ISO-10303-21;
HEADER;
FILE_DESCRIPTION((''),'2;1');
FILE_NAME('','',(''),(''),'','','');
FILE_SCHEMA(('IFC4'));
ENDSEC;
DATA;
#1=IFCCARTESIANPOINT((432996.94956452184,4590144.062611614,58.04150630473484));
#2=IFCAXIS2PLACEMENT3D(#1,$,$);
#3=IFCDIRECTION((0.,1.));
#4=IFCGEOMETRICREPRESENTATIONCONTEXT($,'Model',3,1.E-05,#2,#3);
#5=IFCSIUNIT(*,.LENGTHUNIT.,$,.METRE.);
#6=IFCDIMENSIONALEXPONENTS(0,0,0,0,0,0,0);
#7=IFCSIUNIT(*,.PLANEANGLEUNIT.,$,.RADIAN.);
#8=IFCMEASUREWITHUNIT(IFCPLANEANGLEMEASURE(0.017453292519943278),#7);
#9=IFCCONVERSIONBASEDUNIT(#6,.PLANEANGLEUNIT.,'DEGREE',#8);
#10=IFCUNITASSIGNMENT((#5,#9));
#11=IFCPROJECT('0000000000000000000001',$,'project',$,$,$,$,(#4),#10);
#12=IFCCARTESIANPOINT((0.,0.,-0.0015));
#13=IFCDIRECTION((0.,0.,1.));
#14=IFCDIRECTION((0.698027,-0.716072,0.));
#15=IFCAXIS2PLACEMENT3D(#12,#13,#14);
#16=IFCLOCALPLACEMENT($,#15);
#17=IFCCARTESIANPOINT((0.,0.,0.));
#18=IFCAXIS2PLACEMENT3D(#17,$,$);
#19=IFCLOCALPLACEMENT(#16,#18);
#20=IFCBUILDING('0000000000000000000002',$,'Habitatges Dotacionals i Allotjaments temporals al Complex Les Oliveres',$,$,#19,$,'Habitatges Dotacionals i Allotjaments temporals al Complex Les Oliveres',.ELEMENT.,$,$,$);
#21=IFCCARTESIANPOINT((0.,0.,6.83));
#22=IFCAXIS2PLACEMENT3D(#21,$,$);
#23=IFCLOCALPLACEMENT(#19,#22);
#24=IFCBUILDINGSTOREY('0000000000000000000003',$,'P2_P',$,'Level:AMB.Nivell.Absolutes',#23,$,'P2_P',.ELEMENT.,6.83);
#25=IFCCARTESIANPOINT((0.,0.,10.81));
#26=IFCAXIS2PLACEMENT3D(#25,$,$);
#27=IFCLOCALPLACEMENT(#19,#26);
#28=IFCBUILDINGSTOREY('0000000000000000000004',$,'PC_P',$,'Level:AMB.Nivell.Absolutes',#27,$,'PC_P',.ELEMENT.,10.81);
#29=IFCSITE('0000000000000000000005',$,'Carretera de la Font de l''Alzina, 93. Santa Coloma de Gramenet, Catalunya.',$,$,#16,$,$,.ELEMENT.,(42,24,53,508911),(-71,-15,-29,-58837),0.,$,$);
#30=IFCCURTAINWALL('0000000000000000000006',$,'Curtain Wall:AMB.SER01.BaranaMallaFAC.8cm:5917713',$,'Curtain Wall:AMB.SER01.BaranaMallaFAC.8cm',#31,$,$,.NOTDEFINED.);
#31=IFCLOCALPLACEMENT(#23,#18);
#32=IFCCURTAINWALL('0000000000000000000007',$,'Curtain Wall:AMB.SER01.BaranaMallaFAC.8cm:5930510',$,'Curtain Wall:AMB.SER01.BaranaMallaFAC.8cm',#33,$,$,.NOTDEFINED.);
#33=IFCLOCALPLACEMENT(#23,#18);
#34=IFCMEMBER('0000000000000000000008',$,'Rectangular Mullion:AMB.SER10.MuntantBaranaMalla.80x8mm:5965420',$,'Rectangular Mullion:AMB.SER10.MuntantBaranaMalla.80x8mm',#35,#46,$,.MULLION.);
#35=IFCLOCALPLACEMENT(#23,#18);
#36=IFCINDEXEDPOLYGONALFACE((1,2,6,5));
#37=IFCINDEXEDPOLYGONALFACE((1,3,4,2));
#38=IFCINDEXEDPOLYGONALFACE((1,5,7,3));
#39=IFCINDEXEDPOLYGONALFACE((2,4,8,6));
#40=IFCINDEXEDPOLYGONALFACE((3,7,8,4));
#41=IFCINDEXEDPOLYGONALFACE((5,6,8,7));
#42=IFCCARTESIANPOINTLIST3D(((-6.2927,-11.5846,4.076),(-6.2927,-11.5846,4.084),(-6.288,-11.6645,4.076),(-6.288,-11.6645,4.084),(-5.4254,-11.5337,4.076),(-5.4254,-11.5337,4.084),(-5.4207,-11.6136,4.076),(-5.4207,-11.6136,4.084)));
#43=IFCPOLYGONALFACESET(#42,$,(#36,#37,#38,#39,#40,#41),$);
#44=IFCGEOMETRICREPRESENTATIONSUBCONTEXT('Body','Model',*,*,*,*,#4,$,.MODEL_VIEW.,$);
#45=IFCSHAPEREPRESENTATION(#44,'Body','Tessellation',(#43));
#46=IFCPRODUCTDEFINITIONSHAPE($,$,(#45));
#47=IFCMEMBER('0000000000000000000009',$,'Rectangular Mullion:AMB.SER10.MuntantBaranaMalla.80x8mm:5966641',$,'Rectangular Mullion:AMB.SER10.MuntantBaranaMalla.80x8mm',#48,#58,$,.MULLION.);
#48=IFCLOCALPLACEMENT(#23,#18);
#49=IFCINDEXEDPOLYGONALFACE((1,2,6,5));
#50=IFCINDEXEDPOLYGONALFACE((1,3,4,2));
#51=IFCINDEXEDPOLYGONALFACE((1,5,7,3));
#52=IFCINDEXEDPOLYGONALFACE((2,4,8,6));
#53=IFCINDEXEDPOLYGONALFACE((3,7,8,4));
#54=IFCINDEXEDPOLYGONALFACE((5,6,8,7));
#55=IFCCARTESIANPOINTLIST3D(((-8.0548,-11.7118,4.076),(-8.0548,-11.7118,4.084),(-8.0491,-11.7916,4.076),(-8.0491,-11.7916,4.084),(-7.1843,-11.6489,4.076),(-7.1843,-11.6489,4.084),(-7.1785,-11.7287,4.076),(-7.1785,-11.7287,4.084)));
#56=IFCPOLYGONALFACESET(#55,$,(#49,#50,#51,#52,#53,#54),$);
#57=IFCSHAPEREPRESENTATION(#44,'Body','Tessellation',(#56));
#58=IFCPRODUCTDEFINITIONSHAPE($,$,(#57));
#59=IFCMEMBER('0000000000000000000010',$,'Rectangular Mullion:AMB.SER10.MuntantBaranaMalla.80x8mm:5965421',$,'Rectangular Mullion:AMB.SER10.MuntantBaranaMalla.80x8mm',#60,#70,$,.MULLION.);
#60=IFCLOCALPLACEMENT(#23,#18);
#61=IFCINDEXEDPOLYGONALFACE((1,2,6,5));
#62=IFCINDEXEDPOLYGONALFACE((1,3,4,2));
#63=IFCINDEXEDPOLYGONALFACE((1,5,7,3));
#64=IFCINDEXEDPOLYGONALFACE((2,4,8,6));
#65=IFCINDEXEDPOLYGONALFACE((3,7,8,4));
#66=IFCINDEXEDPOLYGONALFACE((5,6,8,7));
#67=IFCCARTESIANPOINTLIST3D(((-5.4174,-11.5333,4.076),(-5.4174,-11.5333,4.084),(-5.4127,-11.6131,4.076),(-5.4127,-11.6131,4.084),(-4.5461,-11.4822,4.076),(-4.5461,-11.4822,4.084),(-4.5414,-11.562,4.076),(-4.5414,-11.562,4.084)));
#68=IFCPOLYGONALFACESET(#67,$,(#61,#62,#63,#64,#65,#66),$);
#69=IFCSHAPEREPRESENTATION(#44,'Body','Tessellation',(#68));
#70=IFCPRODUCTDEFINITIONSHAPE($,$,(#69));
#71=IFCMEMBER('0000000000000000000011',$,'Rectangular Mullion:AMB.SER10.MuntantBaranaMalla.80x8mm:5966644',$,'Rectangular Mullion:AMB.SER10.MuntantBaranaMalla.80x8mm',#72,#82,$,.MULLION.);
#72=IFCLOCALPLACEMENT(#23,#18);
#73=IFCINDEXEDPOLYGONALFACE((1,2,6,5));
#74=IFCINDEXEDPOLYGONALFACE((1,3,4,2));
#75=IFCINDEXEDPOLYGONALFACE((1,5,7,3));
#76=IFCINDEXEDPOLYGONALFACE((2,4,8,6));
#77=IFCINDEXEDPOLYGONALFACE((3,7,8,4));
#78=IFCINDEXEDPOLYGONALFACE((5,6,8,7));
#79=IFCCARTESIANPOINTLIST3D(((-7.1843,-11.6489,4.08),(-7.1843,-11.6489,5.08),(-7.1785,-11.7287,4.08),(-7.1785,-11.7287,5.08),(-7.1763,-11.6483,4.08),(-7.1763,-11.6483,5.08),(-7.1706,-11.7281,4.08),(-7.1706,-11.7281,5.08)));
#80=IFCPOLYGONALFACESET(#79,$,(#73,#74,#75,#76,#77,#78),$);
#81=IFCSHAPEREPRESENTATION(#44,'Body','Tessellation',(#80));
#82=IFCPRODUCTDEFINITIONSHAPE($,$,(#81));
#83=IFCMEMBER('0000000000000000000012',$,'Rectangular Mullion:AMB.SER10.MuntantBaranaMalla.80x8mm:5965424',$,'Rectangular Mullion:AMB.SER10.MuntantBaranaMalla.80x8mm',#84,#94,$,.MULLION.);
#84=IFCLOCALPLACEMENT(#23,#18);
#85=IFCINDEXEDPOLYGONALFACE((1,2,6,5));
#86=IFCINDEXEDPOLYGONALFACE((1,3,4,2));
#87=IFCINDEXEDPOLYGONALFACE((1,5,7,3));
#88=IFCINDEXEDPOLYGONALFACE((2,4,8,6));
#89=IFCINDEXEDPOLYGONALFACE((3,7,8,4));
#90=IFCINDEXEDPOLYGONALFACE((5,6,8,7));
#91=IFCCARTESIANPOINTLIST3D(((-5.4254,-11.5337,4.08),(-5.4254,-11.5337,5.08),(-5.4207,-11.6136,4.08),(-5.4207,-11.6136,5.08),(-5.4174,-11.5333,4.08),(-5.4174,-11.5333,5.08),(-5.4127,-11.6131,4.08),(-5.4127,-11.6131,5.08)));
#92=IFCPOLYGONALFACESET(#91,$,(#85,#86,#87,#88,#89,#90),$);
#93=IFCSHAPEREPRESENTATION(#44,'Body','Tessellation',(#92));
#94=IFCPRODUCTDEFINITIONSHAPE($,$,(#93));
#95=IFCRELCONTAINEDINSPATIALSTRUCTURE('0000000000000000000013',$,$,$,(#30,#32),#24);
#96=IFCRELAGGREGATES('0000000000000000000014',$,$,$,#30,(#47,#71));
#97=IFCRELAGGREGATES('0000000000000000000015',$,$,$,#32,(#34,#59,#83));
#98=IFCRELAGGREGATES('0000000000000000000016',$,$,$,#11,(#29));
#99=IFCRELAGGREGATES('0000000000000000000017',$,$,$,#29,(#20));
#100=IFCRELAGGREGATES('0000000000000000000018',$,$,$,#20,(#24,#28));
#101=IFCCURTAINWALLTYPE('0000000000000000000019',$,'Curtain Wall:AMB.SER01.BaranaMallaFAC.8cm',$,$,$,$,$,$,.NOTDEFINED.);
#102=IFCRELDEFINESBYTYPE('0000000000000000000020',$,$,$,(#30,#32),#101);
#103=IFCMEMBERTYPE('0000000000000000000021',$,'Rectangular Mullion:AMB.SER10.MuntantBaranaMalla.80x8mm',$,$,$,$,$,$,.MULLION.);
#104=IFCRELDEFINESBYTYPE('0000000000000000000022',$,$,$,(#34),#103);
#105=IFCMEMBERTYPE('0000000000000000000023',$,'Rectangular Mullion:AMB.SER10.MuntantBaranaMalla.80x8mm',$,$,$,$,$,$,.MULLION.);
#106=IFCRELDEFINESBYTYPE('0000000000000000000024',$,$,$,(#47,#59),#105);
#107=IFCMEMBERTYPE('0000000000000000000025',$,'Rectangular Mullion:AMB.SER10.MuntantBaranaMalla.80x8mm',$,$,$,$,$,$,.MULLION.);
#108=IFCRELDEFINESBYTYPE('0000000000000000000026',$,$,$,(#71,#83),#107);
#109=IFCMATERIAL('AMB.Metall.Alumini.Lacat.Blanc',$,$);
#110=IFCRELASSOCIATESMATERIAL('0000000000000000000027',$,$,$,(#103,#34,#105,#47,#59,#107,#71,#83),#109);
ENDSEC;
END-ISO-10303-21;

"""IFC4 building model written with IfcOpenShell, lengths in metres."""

from ifc_helpers import new_model, entity, si_unit, converted_unit, direction, frame, origin, place, context, subcontext, project, spatial, indexed_curve, outline, extrude, source, transform, mapped, material, type_object, type_shapes, element, aggregate, save


model = new_model("IFC4")

# Units and contexts
model_context = context("Model", 3, precision=1e-05, world=frame((432996.94956452184, 4590144.062611614, 58.04150630473484)), true_north=direction((0.0, 1.0)))
body_context = subcontext(model_context, "Body", "Model", "MODEL_VIEW")
ifc_project = project(units=[si_unit("LENGTHUNIT", "METRE"), converted_unit("PLANEANGLEUNIT", "DEGREE", entity("IfcPlaneAngleMeasure", 0.017453292519943278), si_unit("PLANEANGLEUNIT", "RADIAN"), dimensions=[0, 0, 0, 0, 0, 0, 0])], contexts=[model_context])

# Site, building, storey
site_placement = place(None, frame((0.0, 0.0, -0.0015), z_axis=(0.0, 0.0, 1.0), x_axis=(0.698027, -0.716072, 0.0)))
site = spatial("IfcSite", under=ifc_project, at=site_placement, Name="Carretera de la Font de l'Alzina, 93. Santa Coloma de Gramenet, Catalunya.", CompositionType="ELEMENT", RefLatitude=(42, 24, 53, 508911), RefLongitude=(-71, -15, -29, -58837), RefElevation=0.0)
building_placement = place(site_placement, origin())
building = spatial("IfcBuilding", under=site, at=building_placement, Name="Habitatges Dotacionals i Allotjaments temporals al Complex Les Oliveres", LongName="Habitatges Dotacionals i Allotjaments temporals al Complex Les Oliveres", CompositionType="ELEMENT")
storey_1_placement = place(building_placement, frame((0.0, 0.0, 6.83)))
storey_1 = spatial("IfcBuildingStorey", under=building, at=storey_1_placement, Name="P2_P", ObjectType="Level:AMB.Nivell.Absolutes", LongName="P2_P", CompositionType="ELEMENT", Elevation=6.83)

# Curtain walls
curtain_wall_type = type_object("IfcCurtainWallType", Name="Curtain Wall:AMB.SER01.BaranaMallaFAC.8cm", PredefinedType="NOTDEFINED")
curtain_wall_1_placement = place(storey_1_placement, frame((0.0, 0.0, -6.83)))
curtain_wall_1 = element("IfcCurtainWall", 1, at=curtain_wall_1_placement, inside=storey_1, type_object=curtain_wall_type, Name="Curtain Wall:AMB.SER01.BaranaMallaFAC.8cm:5917713", ObjectType="Curtain Wall:AMB.SER01.BaranaMallaFAC.8cm", PredefinedType="NOTDEFINED")
ifc_material_1 = material(Name="AMB.Metall.Alumini.Lacat.Blanc")
curtain_wall_2_placement = place(storey_1_placement, frame((0.0, 0.0, -6.83)))
curtain_wall_2 = element("IfcCurtainWall", 2, at=curtain_wall_2_placement, inside=storey_1, type_object=curtain_wall_type, Name="Curtain Wall:AMB.SER01.BaranaMallaFAC.8cm:5930510", ObjectType="Curtain Wall:AMB.SER01.BaranaMallaFAC.8cm", PredefinedType="NOTDEFINED")

# Members
member_type_1 = type_object("IfcMemberType", Name="Rectangular Mullion:AMB.SER10.MuntantBaranaMalla.80x8mm", PredefinedType="MULLION", material=ifc_material_1)
shared_shape_1 = source(origin(), body_context, "Body", "SweptSolid", [
    extrude(outline(indexed_curve([(-0.004, -0.04), (0.004, -0.04), (0.004, 0.04), (-0.004, 0.04), (-0.004, -0.04)], self_intersect=False)), frame((0.0, -0.04, -0.8688), z_axis=(0.0, 0.0, 1.0), x_axis=(-1.0, 0.0, 0.0)), (0.0, 0.0, 1.0), 0.8688),
])
type_shapes(member_type_1, [shared_shape_1])
member_1_placement = place(curtain_wall_2_placement, frame((-5.4207, -11.6136, 10.91), z_axis=(0.998284, 0.058552, 0.0), x_axis=(0.0, 0.0, 1.0)))
member_1 = element("IfcMember", 3, at=member_1_placement, type_object=member_type_1, material=ifc_material_1, Name="Rectangular Mullion:AMB.SER10.MuntantBaranaMalla.80x8mm:5965420", ObjectType="Rectangular Mullion:AMB.SER10.MuntantBaranaMalla.80x8mm", PredefinedType="MULLION", context=body_context, shape_type="MappedRepresentation", body=[
    mapped(shared_shape_1, transform((0.0, 0.0, 0.0), scale=1.0)),
])
member_type_2 = type_object("IfcMemberType", Name="Rectangular Mullion:AMB.SER10.MuntantBaranaMalla.80x8mm", PredefinedType="MULLION", material=ifc_material_1)
shared_shape_2 = source(origin(), body_context, "Body", "SweptSolid", [
    extrude(outline(indexed_curve([(-0.004, -0.04), (0.004, -0.04), (0.004, 0.04), (-0.004, 0.04), (-0.004, -0.04)], self_intersect=False)), frame((0.0, -0.04, -0.8728), z_axis=(0.0, 0.0, 1.0), x_axis=(-1.0, 0.0, 0.0)), (0.0, 0.0, 1.0), 0.8728),
])
type_shapes(member_type_2, [shared_shape_2])
member_2_placement = place(curtain_wall_1_placement, frame((-7.1785, -11.7287, 10.91), z_axis=(0.9974, 0.072068, 0.0), x_axis=(0.0, 0.0, 1.0)))
member_2 = element("IfcMember", 4, at=member_2_placement, type_object=member_type_2, material=ifc_material_1, Name="Rectangular Mullion:AMB.SER10.MuntantBaranaMalla.80x8mm:5966641", ObjectType="Rectangular Mullion:AMB.SER10.MuntantBaranaMalla.80x8mm", PredefinedType="MULLION", context=body_context, shape_type="MappedRepresentation", body=[
    mapped(shared_shape_2, transform((0.0, 0.0, 0.0), scale=1.0)),
])
member_3_placement = place(curtain_wall_2_placement, frame((-4.5414, -11.562, 10.91), z_axis=(0.998284, 0.058552, 0.0), x_axis=(0.0, 0.0, 1.0)))
member_3 = element("IfcMember", 5, at=member_3_placement, type_object=member_type_2, material=ifc_material_1, Name="Rectangular Mullion:AMB.SER10.MuntantBaranaMalla.80x8mm:5965421", ObjectType="Rectangular Mullion:AMB.SER10.MuntantBaranaMalla.80x8mm", PredefinedType="MULLION", context=body_context, shape_type="MappedRepresentation", body=[
    mapped(shared_shape_2, transform((0.0, 0.0, 0.0), scale=1.0)),
])
member_type_3 = type_object("IfcMemberType", Name="Rectangular Mullion:AMB.SER10.MuntantBaranaMalla.80x8mm", PredefinedType="MULLION", material=ifc_material_1)
shared_shape_3 = source(origin(), body_context, "Body", "SweptSolid", [
    extrude(outline(indexed_curve([(-0.004, -0.04), (0.004, -0.04), (0.004, 0.04), (-0.004, 0.04), (-0.004, -0.04)], self_intersect=False)), frame((0.0, -0.04, -1.0), z_axis=(0.0, 0.0, 1.0), x_axis=(-1.0, 0.0, 0.0)), (0.0, 0.0, 1.0), 1.0),
])
type_shapes(member_type_3, [shared_shape_3])
member_4_placement = place(curtain_wall_1_placement, frame((-7.1745, -11.7284, 10.91), z_axis=(0.0, 0.0, -1.0), x_axis=(0.9974, 0.072068, 0.0)))
member_4 = element("IfcMember", 6, at=member_4_placement, type_object=member_type_3, material=ifc_material_1, Name="Rectangular Mullion:AMB.SER10.MuntantBaranaMalla.80x8mm:5966644", ObjectType="Rectangular Mullion:AMB.SER10.MuntantBaranaMalla.80x8mm", PredefinedType="MULLION", context=body_context, shape_type="MappedRepresentation", body=[
    mapped(shared_shape_3, transform((0.0, 0.0, 0.0), scale=1.0)),
])
member_5_placement = place(curtain_wall_2_placement, frame((-5.4167, -11.6134, 10.91), z_axis=(0.0, 0.0, -1.0), x_axis=(0.998284, 0.058552, 0.0)))
member_5 = element("IfcMember", 7, at=member_5_placement, type_object=member_type_3, material=ifc_material_1, Name="Rectangular Mullion:AMB.SER10.MuntantBaranaMalla.80x8mm:5965424", ObjectType="Rectangular Mullion:AMB.SER10.MuntantBaranaMalla.80x8mm", PredefinedType="MULLION", context=body_context, shape_type="MappedRepresentation", body=[
    mapped(shared_shape_3, transform((0.0, 0.0, 0.0), scale=1.0)),
])

aggregate(curtain_wall_1, [member_2, member_4])
aggregate(curtain_wall_2, [member_1, member_3, member_5])

# Shared definitions
storey_2_placement = place(building_placement, frame((0.0, 0.0, 10.81)))
storey_2 = spatial("IfcBuildingStorey", under=building, at=storey_2_placement, Name="PC_P", ObjectType="Level:AMB.Nivell.Absolutes", LongName="PC_P", CompositionType="ELEMENT", Elevation=10.81)

save(model, "model.ifc")
